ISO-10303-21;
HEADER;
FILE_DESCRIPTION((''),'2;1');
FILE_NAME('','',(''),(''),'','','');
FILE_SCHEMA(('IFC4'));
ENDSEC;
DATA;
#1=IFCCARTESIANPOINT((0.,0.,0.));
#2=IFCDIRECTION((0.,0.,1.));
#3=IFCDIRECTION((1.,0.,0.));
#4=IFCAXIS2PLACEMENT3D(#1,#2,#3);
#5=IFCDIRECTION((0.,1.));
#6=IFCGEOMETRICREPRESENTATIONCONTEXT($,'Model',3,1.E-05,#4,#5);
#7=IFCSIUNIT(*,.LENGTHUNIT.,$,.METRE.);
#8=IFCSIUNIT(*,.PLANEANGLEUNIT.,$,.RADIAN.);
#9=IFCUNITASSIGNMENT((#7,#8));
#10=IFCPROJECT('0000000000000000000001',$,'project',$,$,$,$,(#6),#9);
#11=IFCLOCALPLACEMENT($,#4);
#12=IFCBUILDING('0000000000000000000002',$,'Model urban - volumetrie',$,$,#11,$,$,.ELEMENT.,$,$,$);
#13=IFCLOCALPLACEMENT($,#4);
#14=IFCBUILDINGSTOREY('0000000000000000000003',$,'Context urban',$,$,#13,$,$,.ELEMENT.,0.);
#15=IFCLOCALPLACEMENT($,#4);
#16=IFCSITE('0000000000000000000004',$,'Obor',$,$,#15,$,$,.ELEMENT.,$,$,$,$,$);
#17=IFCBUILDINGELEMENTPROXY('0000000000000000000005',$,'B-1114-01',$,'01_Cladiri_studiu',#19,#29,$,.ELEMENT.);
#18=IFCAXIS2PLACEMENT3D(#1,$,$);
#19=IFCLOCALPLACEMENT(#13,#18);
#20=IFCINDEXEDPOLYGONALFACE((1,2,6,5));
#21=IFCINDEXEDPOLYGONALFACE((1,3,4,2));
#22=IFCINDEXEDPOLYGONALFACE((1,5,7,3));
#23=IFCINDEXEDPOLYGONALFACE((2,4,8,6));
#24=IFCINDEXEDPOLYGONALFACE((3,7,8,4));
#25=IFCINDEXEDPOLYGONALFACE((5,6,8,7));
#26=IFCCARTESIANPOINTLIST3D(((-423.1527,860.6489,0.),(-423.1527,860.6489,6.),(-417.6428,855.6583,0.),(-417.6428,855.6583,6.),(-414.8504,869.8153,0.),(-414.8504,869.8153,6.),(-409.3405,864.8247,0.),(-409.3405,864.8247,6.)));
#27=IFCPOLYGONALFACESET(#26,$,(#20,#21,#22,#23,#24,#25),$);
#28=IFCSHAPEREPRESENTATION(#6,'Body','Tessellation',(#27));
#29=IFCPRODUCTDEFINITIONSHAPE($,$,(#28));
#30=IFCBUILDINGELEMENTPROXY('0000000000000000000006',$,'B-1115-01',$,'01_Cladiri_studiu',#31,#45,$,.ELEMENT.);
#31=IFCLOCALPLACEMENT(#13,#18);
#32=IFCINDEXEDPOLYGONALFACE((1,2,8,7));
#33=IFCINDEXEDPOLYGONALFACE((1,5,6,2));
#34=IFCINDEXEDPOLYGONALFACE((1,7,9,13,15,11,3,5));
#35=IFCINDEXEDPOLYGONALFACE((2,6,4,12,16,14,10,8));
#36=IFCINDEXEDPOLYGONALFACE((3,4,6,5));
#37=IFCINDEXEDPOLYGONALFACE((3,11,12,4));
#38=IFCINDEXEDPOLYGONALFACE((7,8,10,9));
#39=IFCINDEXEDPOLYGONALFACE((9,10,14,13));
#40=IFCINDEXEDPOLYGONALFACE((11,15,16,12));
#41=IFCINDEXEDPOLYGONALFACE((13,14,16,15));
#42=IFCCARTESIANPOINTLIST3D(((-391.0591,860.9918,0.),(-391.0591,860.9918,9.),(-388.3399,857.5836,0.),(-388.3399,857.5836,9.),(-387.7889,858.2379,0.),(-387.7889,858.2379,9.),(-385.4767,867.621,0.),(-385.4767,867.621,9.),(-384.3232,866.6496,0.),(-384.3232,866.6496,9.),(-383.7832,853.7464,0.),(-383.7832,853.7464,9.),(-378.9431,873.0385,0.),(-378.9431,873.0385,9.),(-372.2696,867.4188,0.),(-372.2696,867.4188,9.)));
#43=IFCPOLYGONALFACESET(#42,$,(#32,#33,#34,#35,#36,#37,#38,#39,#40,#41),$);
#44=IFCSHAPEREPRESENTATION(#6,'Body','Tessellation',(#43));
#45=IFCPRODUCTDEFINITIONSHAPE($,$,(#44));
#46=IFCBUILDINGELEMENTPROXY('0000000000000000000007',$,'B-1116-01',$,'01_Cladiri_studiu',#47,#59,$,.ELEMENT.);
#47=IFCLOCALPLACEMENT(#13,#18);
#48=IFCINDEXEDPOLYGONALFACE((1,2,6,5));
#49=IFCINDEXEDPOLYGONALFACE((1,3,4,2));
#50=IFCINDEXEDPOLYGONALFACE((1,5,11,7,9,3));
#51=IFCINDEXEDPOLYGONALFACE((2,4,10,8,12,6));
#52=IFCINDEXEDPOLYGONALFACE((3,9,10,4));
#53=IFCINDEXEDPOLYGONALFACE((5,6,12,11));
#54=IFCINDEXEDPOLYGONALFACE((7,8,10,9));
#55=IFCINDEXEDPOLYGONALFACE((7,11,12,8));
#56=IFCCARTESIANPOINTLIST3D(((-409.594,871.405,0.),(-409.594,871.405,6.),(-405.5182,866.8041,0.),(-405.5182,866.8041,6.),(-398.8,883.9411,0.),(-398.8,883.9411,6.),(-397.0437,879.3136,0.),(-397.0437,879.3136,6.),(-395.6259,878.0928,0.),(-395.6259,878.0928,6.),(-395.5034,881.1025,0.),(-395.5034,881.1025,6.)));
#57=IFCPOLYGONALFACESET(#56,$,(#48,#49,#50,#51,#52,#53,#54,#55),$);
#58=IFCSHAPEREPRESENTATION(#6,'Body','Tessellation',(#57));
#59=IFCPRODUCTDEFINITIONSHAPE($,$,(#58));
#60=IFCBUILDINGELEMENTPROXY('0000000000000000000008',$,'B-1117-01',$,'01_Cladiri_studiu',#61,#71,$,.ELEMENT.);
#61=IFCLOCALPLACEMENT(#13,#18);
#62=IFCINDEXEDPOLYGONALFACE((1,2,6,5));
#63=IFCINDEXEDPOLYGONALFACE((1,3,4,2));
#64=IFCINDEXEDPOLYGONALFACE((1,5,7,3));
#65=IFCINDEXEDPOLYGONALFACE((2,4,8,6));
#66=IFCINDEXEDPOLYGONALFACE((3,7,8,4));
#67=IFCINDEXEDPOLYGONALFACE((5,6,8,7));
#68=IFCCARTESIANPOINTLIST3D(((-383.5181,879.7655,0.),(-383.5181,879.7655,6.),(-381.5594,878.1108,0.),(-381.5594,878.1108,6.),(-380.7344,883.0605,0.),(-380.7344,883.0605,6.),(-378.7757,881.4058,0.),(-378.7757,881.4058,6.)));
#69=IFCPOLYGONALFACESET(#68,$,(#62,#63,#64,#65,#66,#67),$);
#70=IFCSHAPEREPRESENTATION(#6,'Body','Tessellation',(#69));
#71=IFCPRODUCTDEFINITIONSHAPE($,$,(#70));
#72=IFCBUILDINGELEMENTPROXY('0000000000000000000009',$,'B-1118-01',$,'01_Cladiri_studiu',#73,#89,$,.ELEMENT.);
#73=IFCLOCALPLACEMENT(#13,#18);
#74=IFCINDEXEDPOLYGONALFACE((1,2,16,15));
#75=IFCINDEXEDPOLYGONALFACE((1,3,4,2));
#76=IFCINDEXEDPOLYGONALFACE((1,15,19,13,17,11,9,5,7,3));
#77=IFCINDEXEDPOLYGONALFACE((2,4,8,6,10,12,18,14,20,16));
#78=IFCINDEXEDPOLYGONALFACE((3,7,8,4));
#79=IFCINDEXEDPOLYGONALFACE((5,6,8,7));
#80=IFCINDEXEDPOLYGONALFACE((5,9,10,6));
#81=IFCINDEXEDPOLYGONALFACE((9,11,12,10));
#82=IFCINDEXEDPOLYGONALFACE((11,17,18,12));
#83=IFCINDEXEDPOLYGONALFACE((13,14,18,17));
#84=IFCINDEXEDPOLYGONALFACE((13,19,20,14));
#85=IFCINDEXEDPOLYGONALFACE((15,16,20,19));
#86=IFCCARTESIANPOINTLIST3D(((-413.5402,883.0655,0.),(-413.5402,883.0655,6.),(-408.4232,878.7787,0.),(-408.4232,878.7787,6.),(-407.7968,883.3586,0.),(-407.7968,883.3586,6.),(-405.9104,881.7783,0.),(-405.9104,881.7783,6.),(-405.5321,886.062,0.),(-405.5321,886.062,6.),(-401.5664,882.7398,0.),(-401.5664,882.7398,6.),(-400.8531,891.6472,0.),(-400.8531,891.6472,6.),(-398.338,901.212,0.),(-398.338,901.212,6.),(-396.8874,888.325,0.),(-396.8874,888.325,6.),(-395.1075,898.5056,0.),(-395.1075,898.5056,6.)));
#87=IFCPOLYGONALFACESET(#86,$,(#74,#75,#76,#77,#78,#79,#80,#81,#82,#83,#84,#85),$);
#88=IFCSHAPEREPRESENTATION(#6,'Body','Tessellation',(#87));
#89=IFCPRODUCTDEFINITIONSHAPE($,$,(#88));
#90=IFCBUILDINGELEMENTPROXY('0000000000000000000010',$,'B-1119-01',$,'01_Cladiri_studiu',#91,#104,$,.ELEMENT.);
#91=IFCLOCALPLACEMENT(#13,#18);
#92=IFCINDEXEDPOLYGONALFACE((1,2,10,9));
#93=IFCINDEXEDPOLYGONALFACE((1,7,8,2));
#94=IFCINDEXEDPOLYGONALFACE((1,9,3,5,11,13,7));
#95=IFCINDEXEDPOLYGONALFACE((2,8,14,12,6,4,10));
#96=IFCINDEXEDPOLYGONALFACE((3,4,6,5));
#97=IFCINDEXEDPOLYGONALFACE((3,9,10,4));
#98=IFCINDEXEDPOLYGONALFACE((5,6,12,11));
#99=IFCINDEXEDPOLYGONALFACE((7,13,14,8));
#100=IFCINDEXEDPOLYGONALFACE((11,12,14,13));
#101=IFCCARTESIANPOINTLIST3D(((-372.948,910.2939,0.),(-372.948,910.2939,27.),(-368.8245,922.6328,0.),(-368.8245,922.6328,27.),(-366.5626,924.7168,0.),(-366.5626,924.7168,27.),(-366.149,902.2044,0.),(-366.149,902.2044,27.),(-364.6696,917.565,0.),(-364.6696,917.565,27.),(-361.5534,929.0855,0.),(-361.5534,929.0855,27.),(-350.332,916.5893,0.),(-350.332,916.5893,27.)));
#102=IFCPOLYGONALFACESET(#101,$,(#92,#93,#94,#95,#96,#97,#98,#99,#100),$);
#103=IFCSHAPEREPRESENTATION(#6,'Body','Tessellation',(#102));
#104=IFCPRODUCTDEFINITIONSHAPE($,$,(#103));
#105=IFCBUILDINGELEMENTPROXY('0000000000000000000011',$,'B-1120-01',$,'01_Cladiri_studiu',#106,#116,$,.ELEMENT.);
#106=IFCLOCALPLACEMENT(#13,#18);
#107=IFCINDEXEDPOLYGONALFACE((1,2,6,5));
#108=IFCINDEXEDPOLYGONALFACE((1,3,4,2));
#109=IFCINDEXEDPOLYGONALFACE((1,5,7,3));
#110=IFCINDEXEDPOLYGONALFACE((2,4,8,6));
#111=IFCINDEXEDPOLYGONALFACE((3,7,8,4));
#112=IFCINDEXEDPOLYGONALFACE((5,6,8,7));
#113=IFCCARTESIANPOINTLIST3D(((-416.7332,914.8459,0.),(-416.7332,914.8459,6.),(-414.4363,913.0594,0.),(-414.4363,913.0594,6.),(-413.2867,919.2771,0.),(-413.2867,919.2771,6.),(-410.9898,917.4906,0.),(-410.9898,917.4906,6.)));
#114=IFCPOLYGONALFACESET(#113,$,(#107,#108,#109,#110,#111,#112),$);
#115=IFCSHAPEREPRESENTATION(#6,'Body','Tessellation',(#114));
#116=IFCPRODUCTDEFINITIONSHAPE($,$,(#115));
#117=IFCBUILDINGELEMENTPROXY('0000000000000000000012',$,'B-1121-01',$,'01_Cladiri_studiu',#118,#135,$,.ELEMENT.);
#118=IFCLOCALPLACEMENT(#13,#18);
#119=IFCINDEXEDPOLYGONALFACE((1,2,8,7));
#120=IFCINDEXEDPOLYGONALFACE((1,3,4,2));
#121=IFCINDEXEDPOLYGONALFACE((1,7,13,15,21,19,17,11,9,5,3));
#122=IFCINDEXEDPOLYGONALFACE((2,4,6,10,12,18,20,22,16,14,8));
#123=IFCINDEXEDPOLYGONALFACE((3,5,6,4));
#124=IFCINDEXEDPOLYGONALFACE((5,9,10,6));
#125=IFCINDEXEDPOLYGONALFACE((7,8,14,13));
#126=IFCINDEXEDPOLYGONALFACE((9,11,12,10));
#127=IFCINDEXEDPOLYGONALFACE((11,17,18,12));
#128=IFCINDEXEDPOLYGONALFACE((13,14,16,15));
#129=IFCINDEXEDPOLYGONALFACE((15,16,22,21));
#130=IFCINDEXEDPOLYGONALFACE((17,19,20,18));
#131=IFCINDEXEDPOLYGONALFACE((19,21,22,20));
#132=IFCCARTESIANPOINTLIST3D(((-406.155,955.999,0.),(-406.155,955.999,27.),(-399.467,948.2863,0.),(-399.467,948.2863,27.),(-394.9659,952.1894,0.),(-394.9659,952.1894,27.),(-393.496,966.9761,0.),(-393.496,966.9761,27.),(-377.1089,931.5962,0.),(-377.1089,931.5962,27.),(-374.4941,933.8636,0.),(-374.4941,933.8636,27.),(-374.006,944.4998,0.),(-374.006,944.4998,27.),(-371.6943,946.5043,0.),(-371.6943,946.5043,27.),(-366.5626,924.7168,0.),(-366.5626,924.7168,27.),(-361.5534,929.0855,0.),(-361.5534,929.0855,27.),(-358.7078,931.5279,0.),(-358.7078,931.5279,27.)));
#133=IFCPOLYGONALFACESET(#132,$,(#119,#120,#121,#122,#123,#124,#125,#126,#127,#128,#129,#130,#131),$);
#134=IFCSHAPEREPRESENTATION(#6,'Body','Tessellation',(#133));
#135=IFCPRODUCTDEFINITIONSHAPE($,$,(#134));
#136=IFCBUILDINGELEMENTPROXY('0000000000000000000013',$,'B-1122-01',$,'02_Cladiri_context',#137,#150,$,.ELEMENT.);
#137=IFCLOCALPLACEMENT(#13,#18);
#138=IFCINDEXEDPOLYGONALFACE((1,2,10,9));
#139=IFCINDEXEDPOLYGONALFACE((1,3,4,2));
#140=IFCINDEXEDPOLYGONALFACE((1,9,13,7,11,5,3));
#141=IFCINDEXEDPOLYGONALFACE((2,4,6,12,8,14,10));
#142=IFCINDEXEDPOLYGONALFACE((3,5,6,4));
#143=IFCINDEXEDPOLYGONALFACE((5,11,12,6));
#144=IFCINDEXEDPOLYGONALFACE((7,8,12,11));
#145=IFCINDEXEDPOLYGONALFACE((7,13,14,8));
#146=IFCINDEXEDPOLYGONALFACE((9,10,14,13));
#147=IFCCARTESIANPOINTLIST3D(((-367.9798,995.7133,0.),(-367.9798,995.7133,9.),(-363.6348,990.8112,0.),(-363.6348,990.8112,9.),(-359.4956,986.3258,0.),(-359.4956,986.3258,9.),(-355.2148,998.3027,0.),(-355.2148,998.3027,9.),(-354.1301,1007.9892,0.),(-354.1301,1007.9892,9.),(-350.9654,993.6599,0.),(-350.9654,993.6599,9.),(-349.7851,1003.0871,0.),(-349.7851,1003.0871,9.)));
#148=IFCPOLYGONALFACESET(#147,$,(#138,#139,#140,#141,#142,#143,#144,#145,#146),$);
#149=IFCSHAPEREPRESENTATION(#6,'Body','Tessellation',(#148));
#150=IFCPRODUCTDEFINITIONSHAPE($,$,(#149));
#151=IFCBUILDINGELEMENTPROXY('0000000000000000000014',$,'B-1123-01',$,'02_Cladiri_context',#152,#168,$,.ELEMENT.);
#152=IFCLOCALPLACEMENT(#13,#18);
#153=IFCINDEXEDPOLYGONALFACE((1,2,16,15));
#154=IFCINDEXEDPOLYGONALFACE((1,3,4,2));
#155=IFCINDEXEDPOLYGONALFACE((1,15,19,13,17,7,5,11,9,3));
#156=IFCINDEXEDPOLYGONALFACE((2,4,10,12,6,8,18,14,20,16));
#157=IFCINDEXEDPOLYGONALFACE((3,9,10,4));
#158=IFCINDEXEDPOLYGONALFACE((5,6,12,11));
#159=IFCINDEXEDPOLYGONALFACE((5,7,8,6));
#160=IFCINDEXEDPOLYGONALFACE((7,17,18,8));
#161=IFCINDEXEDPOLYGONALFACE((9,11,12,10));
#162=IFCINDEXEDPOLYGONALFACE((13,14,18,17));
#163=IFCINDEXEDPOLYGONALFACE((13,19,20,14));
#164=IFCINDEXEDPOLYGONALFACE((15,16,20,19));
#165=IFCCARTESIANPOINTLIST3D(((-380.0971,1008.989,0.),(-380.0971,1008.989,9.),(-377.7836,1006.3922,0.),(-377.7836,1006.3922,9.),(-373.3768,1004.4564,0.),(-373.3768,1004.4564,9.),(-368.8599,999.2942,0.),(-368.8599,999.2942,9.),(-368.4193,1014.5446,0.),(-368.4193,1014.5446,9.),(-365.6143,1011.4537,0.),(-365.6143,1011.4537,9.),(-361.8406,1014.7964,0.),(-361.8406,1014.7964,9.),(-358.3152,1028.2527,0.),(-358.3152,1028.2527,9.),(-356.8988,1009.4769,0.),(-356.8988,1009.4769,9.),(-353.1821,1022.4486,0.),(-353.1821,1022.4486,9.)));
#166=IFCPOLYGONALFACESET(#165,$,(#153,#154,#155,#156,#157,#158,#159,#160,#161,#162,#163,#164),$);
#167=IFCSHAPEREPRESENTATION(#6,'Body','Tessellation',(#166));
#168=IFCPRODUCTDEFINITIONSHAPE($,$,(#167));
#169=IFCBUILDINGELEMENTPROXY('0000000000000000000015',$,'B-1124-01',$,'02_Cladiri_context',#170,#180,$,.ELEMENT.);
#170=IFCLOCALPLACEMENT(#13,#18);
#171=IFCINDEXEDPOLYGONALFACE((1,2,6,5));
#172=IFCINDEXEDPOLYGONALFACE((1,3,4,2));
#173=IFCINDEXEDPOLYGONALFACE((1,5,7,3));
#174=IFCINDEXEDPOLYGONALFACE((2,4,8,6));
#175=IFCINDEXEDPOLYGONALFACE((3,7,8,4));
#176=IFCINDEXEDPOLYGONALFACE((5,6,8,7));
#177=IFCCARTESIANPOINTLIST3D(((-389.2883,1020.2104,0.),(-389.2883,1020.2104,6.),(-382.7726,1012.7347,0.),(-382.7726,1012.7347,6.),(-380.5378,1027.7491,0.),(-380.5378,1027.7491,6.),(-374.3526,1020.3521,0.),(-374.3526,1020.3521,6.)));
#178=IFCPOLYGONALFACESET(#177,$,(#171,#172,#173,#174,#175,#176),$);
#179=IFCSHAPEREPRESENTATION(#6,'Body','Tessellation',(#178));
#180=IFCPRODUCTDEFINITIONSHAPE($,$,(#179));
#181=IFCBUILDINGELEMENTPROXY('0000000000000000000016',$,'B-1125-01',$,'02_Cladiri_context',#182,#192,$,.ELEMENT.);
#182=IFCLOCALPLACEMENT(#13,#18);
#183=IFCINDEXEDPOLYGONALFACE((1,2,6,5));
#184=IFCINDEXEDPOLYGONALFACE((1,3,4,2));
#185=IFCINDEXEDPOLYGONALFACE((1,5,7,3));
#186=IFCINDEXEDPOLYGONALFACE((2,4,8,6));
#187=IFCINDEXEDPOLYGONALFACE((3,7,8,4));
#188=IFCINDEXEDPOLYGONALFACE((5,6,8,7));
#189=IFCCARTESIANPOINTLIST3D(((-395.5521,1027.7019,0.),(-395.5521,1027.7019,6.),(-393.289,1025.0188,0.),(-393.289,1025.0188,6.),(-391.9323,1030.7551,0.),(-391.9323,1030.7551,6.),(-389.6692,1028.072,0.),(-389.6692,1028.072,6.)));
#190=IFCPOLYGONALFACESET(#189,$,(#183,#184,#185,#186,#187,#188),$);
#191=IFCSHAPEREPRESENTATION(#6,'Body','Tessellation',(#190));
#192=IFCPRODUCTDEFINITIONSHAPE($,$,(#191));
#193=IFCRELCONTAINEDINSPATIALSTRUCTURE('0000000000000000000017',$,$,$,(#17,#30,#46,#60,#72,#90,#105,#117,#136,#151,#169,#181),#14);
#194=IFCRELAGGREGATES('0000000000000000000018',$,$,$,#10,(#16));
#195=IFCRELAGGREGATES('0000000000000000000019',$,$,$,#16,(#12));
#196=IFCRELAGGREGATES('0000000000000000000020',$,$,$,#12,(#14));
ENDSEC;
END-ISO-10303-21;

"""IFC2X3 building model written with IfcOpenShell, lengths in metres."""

from ifc_helpers import new_model, si_unit, direction, origin_with_axes, place, context, project, spatial, polyline, outline, extrude, element, save


model = new_model("IFC2X3")

# Units and contexts
model_context = context("Model", 3, precision=1e-05, world=origin_with_axes(), true_north=direction((0.0, 1.0)))
ifc_project = project(units=[si_unit("LENGTHUNIT", "METRE"), si_unit("PLANEANGLEUNIT", "RADIAN")], contexts=[model_context])

# Site, building, storey
site_placement = place(None, origin_with_axes())
site = spatial("IfcSite", under=ifc_project, at=site_placement, Name="Obor", CompositionType="ELEMENT")
building_placement = place(None, origin_with_axes())
building = spatial("IfcBuilding", under=site, at=building_placement, Name="Model urban - volumetrie", CompositionType="ELEMENT")
storey_placement = place(None, origin_with_axes())
storey = spatial("IfcBuildingStorey", under=building, at=storey_placement, Name="Context urban", CompositionType="ELEMENT", Elevation=0.0)

# Building element proxies
proxy_1_placement = place(None, origin_with_axes())
element("IfcBuildingElementProxy", 1, at=proxy_1_placement, inside=storey, Name="B-1114-01", ObjectType="01_Cladiri_studiu", CompositionType="ELEMENT", context=model_context, shape_type="SweptSolid", body=[
    extrude(outline(polyline([(-409.3405, 864.8247), (-414.8504, 869.8153), (-423.1527, 860.6489), (-417.6428, 855.6583), (-409.3405, 864.8247)])), origin_with_axes(), (0.0, 0.0, 1.0), 6.0),
])
proxy_2_placement = place(None, origin_with_axes())
element("IfcBuildingElementProxy", 2, at=proxy_2_placement, inside=storey, Name="B-1115-01", ObjectType="01_Cladiri_studiu", CompositionType="ELEMENT", context=model_context, shape_type="SweptSolid", body=[
    extrude(outline(polyline([(-378.9431, 873.0385), (-384.3232, 866.6496), (-385.4767, 867.621), (-391.0591, 860.9918), (-387.7889, 858.2379), (-388.3399, 857.5836), (-383.7832, 853.7464), (-372.2696, 867.4188), (-378.9431, 873.0385)])), origin_with_axes(), (0.0, 0.0, 1.0), 9.0),
])
proxy_3_placement = place(None, origin_with_axes())
element("IfcBuildingElementProxy", 3, at=proxy_3_placement, inside=storey, Name="B-1116-01", ObjectType="01_Cladiri_studiu", CompositionType="ELEMENT", context=model_context, shape_type="SweptSolid", body=[
    extrude(outline(polyline([(-397.0437, 879.3136), (-395.5034, 881.1025), (-398.8, 883.9411), (-409.594, 871.405), (-405.5182, 866.8041), (-395.6259, 878.0928), (-397.0437, 879.3136)])), origin_with_axes(), (0.0, 0.0, 1.0), 6.0),
])
proxy_4_placement = place(None, origin_with_axes())
element("IfcBuildingElementProxy", 4, at=proxy_4_placement, inside=storey, Name="B-1117-01", ObjectType="01_Cladiri_studiu", CompositionType="ELEMENT", context=model_context, shape_type="SweptSolid", body=[
    extrude(outline(polyline([(-381.5594, 878.1108), (-378.7757, 881.4058), (-380.7344, 883.0605), (-383.5181, 879.7655), (-381.5594, 878.1108)])), origin_with_axes(), (0.0, 0.0, 1.0), 6.0),
])
proxy_5_placement = place(None, origin_with_axes())
element("IfcBuildingElementProxy", 5, at=proxy_5_placement, inside=storey, Name="B-1118-01", ObjectType="01_Cladiri_studiu", CompositionType="ELEMENT", context=model_context, shape_type="SweptSolid", body=[
    extrude(outline(polyline([(-405.9104, 881.7783), (-407.7968, 883.3586), (-405.5321, 886.062), (-401.5664, 882.7398), (-396.8874, 888.325), (-400.8531, 891.6472), (-395.1075, 898.5056), (-398.338, 901.212), (-413.5402, 883.0655), (-408.4232, 878.7787), (-405.9104, 881.7783)])), origin_with_axes(), (0.0, 0.0, 1.0), 6.0),
])
proxy_6_placement = place(None, origin_with_axes())
element("IfcBuildingElementProxy", 6, at=proxy_6_placement, inside=storey, Name="B-1119-01", ObjectType="01_Cladiri_studiu", CompositionType="ELEMENT", context=model_context, shape_type="SweptSolid", body=[
    extrude(outline(polyline([(-361.5534, 929.0855), (-366.5626, 924.7168), (-368.8245, 922.6328), (-364.6696, 917.565), (-372.948, 910.2939), (-366.149, 902.2044), (-350.332, 916.5893), (-361.5534, 929.0855)])), origin_with_axes(), (0.0, 0.0, 1.0), 27.0),
])
proxy_7_placement = place(None, origin_with_axes())
element("IfcBuildingElementProxy", 7, at=proxy_7_placement, inside=storey, Name="B-1120-01", ObjectType="01_Cladiri_studiu", CompositionType="ELEMENT", context=model_context, shape_type="SweptSolid", body=[
    extrude(outline(polyline([(-410.9898, 917.4906), (-413.2867, 919.2771), (-416.7332, 914.8459), (-414.4363, 913.0594), (-410.9898, 917.4906)])), origin_with_axes(), (0.0, 0.0, 1.0), 6.0),
])
proxy_8_placement = place(None, origin_with_axes())
element("IfcBuildingElementProxy", 8, at=proxy_8_placement, inside=storey, Name="B-1121-01", ObjectType="01_Cladiri_studiu", CompositionType="ELEMENT", context=model_context, shape_type="SweptSolid", body=[
    extrude(outline(polyline([(-374.006, 944.4998), (-393.496, 966.9761), (-406.155, 955.999), (-399.467, 948.2863), (-394.9659, 952.1894), (-377.1089, 931.5962), (-374.4941, 933.8636), (-366.5626, 924.7168), (-361.5534, 929.0855), (-358.7078, 931.5279), (-371.6943, 946.5043), (-374.006, 944.4998)])), origin_with_axes(), (0.0, 0.0, 1.0), 27.0),
])
proxy_9_placement = place(None, origin_with_axes())
element("IfcBuildingElementProxy", 9, at=proxy_9_placement, inside=storey, Name="B-1122-01", ObjectType="02_Cladiri_context", CompositionType="ELEMENT", context=model_context, shape_type="SweptSolid", body=[
    extrude(outline(polyline([(-354.1301, 1007.9892), (-367.9798, 995.7133), (-363.6348, 990.8112), (-359.4956, 986.3258), (-350.9654, 993.6599), (-355.2148, 998.3027), (-349.7851, 1003.0871), (-354.1301, 1007.9892)])), origin_with_axes(), (0.0, 0.0, 1.0), 9.0),
])
proxy_10_placement = place(None, origin_with_axes())
element("IfcBuildingElementProxy", 10, at=proxy_10_placement, inside=storey, Name="B-1123-01", ObjectType="02_Cladiri_context", CompositionType="ELEMENT", context=model_context, shape_type="SweptSolid", body=[
    extrude(outline(polyline([(-365.6143, 1011.4537), (-373.3768, 1004.4564), (-368.8599, 999.2942), (-356.8988, 1009.4769), (-361.8406, 1014.7964), (-353.1821, 1022.4486), (-358.3152, 1028.2527), (-380.0971, 1008.989), (-377.7836, 1006.3922), (-368.4193, 1014.5446), (-365.6143, 1011.4537)])), origin_with_axes(), (0.0, 0.0, 1.0), 9.0),
])
proxy_11_placement = place(None, origin_with_axes())
element("IfcBuildingElementProxy", 11, at=proxy_11_placement, inside=storey, Name="B-1124-01", ObjectType="02_Cladiri_context", CompositionType="ELEMENT", context=model_context, shape_type="SweptSolid", body=[
    extrude(outline(polyline([(-389.2883, 1020.2104), (-382.7726, 1012.7347), (-374.3526, 1020.3521), (-380.5378, 1027.7491), (-389.2883, 1020.2104)])), origin_with_axes(), (0.0, 0.0, 1.0), 6.0),
])
proxy_12_placement = place(None, origin_with_axes())
element("IfcBuildingElementProxy", 12, at=proxy_12_placement, inside=storey, Name="B-1125-01", ObjectType="02_Cladiri_context", CompositionType="ELEMENT", context=model_context, shape_type="SweptSolid", body=[
    extrude(outline(polyline([(-389.6692, 1028.072), (-391.9323, 1030.7551), (-395.5521, 1027.7019), (-393.289, 1025.0188), (-389.6692, 1028.072)])), origin_with_axes(), (0.0, 0.0, 1.0), 6.0),
])

save(model, "model.ifc")
